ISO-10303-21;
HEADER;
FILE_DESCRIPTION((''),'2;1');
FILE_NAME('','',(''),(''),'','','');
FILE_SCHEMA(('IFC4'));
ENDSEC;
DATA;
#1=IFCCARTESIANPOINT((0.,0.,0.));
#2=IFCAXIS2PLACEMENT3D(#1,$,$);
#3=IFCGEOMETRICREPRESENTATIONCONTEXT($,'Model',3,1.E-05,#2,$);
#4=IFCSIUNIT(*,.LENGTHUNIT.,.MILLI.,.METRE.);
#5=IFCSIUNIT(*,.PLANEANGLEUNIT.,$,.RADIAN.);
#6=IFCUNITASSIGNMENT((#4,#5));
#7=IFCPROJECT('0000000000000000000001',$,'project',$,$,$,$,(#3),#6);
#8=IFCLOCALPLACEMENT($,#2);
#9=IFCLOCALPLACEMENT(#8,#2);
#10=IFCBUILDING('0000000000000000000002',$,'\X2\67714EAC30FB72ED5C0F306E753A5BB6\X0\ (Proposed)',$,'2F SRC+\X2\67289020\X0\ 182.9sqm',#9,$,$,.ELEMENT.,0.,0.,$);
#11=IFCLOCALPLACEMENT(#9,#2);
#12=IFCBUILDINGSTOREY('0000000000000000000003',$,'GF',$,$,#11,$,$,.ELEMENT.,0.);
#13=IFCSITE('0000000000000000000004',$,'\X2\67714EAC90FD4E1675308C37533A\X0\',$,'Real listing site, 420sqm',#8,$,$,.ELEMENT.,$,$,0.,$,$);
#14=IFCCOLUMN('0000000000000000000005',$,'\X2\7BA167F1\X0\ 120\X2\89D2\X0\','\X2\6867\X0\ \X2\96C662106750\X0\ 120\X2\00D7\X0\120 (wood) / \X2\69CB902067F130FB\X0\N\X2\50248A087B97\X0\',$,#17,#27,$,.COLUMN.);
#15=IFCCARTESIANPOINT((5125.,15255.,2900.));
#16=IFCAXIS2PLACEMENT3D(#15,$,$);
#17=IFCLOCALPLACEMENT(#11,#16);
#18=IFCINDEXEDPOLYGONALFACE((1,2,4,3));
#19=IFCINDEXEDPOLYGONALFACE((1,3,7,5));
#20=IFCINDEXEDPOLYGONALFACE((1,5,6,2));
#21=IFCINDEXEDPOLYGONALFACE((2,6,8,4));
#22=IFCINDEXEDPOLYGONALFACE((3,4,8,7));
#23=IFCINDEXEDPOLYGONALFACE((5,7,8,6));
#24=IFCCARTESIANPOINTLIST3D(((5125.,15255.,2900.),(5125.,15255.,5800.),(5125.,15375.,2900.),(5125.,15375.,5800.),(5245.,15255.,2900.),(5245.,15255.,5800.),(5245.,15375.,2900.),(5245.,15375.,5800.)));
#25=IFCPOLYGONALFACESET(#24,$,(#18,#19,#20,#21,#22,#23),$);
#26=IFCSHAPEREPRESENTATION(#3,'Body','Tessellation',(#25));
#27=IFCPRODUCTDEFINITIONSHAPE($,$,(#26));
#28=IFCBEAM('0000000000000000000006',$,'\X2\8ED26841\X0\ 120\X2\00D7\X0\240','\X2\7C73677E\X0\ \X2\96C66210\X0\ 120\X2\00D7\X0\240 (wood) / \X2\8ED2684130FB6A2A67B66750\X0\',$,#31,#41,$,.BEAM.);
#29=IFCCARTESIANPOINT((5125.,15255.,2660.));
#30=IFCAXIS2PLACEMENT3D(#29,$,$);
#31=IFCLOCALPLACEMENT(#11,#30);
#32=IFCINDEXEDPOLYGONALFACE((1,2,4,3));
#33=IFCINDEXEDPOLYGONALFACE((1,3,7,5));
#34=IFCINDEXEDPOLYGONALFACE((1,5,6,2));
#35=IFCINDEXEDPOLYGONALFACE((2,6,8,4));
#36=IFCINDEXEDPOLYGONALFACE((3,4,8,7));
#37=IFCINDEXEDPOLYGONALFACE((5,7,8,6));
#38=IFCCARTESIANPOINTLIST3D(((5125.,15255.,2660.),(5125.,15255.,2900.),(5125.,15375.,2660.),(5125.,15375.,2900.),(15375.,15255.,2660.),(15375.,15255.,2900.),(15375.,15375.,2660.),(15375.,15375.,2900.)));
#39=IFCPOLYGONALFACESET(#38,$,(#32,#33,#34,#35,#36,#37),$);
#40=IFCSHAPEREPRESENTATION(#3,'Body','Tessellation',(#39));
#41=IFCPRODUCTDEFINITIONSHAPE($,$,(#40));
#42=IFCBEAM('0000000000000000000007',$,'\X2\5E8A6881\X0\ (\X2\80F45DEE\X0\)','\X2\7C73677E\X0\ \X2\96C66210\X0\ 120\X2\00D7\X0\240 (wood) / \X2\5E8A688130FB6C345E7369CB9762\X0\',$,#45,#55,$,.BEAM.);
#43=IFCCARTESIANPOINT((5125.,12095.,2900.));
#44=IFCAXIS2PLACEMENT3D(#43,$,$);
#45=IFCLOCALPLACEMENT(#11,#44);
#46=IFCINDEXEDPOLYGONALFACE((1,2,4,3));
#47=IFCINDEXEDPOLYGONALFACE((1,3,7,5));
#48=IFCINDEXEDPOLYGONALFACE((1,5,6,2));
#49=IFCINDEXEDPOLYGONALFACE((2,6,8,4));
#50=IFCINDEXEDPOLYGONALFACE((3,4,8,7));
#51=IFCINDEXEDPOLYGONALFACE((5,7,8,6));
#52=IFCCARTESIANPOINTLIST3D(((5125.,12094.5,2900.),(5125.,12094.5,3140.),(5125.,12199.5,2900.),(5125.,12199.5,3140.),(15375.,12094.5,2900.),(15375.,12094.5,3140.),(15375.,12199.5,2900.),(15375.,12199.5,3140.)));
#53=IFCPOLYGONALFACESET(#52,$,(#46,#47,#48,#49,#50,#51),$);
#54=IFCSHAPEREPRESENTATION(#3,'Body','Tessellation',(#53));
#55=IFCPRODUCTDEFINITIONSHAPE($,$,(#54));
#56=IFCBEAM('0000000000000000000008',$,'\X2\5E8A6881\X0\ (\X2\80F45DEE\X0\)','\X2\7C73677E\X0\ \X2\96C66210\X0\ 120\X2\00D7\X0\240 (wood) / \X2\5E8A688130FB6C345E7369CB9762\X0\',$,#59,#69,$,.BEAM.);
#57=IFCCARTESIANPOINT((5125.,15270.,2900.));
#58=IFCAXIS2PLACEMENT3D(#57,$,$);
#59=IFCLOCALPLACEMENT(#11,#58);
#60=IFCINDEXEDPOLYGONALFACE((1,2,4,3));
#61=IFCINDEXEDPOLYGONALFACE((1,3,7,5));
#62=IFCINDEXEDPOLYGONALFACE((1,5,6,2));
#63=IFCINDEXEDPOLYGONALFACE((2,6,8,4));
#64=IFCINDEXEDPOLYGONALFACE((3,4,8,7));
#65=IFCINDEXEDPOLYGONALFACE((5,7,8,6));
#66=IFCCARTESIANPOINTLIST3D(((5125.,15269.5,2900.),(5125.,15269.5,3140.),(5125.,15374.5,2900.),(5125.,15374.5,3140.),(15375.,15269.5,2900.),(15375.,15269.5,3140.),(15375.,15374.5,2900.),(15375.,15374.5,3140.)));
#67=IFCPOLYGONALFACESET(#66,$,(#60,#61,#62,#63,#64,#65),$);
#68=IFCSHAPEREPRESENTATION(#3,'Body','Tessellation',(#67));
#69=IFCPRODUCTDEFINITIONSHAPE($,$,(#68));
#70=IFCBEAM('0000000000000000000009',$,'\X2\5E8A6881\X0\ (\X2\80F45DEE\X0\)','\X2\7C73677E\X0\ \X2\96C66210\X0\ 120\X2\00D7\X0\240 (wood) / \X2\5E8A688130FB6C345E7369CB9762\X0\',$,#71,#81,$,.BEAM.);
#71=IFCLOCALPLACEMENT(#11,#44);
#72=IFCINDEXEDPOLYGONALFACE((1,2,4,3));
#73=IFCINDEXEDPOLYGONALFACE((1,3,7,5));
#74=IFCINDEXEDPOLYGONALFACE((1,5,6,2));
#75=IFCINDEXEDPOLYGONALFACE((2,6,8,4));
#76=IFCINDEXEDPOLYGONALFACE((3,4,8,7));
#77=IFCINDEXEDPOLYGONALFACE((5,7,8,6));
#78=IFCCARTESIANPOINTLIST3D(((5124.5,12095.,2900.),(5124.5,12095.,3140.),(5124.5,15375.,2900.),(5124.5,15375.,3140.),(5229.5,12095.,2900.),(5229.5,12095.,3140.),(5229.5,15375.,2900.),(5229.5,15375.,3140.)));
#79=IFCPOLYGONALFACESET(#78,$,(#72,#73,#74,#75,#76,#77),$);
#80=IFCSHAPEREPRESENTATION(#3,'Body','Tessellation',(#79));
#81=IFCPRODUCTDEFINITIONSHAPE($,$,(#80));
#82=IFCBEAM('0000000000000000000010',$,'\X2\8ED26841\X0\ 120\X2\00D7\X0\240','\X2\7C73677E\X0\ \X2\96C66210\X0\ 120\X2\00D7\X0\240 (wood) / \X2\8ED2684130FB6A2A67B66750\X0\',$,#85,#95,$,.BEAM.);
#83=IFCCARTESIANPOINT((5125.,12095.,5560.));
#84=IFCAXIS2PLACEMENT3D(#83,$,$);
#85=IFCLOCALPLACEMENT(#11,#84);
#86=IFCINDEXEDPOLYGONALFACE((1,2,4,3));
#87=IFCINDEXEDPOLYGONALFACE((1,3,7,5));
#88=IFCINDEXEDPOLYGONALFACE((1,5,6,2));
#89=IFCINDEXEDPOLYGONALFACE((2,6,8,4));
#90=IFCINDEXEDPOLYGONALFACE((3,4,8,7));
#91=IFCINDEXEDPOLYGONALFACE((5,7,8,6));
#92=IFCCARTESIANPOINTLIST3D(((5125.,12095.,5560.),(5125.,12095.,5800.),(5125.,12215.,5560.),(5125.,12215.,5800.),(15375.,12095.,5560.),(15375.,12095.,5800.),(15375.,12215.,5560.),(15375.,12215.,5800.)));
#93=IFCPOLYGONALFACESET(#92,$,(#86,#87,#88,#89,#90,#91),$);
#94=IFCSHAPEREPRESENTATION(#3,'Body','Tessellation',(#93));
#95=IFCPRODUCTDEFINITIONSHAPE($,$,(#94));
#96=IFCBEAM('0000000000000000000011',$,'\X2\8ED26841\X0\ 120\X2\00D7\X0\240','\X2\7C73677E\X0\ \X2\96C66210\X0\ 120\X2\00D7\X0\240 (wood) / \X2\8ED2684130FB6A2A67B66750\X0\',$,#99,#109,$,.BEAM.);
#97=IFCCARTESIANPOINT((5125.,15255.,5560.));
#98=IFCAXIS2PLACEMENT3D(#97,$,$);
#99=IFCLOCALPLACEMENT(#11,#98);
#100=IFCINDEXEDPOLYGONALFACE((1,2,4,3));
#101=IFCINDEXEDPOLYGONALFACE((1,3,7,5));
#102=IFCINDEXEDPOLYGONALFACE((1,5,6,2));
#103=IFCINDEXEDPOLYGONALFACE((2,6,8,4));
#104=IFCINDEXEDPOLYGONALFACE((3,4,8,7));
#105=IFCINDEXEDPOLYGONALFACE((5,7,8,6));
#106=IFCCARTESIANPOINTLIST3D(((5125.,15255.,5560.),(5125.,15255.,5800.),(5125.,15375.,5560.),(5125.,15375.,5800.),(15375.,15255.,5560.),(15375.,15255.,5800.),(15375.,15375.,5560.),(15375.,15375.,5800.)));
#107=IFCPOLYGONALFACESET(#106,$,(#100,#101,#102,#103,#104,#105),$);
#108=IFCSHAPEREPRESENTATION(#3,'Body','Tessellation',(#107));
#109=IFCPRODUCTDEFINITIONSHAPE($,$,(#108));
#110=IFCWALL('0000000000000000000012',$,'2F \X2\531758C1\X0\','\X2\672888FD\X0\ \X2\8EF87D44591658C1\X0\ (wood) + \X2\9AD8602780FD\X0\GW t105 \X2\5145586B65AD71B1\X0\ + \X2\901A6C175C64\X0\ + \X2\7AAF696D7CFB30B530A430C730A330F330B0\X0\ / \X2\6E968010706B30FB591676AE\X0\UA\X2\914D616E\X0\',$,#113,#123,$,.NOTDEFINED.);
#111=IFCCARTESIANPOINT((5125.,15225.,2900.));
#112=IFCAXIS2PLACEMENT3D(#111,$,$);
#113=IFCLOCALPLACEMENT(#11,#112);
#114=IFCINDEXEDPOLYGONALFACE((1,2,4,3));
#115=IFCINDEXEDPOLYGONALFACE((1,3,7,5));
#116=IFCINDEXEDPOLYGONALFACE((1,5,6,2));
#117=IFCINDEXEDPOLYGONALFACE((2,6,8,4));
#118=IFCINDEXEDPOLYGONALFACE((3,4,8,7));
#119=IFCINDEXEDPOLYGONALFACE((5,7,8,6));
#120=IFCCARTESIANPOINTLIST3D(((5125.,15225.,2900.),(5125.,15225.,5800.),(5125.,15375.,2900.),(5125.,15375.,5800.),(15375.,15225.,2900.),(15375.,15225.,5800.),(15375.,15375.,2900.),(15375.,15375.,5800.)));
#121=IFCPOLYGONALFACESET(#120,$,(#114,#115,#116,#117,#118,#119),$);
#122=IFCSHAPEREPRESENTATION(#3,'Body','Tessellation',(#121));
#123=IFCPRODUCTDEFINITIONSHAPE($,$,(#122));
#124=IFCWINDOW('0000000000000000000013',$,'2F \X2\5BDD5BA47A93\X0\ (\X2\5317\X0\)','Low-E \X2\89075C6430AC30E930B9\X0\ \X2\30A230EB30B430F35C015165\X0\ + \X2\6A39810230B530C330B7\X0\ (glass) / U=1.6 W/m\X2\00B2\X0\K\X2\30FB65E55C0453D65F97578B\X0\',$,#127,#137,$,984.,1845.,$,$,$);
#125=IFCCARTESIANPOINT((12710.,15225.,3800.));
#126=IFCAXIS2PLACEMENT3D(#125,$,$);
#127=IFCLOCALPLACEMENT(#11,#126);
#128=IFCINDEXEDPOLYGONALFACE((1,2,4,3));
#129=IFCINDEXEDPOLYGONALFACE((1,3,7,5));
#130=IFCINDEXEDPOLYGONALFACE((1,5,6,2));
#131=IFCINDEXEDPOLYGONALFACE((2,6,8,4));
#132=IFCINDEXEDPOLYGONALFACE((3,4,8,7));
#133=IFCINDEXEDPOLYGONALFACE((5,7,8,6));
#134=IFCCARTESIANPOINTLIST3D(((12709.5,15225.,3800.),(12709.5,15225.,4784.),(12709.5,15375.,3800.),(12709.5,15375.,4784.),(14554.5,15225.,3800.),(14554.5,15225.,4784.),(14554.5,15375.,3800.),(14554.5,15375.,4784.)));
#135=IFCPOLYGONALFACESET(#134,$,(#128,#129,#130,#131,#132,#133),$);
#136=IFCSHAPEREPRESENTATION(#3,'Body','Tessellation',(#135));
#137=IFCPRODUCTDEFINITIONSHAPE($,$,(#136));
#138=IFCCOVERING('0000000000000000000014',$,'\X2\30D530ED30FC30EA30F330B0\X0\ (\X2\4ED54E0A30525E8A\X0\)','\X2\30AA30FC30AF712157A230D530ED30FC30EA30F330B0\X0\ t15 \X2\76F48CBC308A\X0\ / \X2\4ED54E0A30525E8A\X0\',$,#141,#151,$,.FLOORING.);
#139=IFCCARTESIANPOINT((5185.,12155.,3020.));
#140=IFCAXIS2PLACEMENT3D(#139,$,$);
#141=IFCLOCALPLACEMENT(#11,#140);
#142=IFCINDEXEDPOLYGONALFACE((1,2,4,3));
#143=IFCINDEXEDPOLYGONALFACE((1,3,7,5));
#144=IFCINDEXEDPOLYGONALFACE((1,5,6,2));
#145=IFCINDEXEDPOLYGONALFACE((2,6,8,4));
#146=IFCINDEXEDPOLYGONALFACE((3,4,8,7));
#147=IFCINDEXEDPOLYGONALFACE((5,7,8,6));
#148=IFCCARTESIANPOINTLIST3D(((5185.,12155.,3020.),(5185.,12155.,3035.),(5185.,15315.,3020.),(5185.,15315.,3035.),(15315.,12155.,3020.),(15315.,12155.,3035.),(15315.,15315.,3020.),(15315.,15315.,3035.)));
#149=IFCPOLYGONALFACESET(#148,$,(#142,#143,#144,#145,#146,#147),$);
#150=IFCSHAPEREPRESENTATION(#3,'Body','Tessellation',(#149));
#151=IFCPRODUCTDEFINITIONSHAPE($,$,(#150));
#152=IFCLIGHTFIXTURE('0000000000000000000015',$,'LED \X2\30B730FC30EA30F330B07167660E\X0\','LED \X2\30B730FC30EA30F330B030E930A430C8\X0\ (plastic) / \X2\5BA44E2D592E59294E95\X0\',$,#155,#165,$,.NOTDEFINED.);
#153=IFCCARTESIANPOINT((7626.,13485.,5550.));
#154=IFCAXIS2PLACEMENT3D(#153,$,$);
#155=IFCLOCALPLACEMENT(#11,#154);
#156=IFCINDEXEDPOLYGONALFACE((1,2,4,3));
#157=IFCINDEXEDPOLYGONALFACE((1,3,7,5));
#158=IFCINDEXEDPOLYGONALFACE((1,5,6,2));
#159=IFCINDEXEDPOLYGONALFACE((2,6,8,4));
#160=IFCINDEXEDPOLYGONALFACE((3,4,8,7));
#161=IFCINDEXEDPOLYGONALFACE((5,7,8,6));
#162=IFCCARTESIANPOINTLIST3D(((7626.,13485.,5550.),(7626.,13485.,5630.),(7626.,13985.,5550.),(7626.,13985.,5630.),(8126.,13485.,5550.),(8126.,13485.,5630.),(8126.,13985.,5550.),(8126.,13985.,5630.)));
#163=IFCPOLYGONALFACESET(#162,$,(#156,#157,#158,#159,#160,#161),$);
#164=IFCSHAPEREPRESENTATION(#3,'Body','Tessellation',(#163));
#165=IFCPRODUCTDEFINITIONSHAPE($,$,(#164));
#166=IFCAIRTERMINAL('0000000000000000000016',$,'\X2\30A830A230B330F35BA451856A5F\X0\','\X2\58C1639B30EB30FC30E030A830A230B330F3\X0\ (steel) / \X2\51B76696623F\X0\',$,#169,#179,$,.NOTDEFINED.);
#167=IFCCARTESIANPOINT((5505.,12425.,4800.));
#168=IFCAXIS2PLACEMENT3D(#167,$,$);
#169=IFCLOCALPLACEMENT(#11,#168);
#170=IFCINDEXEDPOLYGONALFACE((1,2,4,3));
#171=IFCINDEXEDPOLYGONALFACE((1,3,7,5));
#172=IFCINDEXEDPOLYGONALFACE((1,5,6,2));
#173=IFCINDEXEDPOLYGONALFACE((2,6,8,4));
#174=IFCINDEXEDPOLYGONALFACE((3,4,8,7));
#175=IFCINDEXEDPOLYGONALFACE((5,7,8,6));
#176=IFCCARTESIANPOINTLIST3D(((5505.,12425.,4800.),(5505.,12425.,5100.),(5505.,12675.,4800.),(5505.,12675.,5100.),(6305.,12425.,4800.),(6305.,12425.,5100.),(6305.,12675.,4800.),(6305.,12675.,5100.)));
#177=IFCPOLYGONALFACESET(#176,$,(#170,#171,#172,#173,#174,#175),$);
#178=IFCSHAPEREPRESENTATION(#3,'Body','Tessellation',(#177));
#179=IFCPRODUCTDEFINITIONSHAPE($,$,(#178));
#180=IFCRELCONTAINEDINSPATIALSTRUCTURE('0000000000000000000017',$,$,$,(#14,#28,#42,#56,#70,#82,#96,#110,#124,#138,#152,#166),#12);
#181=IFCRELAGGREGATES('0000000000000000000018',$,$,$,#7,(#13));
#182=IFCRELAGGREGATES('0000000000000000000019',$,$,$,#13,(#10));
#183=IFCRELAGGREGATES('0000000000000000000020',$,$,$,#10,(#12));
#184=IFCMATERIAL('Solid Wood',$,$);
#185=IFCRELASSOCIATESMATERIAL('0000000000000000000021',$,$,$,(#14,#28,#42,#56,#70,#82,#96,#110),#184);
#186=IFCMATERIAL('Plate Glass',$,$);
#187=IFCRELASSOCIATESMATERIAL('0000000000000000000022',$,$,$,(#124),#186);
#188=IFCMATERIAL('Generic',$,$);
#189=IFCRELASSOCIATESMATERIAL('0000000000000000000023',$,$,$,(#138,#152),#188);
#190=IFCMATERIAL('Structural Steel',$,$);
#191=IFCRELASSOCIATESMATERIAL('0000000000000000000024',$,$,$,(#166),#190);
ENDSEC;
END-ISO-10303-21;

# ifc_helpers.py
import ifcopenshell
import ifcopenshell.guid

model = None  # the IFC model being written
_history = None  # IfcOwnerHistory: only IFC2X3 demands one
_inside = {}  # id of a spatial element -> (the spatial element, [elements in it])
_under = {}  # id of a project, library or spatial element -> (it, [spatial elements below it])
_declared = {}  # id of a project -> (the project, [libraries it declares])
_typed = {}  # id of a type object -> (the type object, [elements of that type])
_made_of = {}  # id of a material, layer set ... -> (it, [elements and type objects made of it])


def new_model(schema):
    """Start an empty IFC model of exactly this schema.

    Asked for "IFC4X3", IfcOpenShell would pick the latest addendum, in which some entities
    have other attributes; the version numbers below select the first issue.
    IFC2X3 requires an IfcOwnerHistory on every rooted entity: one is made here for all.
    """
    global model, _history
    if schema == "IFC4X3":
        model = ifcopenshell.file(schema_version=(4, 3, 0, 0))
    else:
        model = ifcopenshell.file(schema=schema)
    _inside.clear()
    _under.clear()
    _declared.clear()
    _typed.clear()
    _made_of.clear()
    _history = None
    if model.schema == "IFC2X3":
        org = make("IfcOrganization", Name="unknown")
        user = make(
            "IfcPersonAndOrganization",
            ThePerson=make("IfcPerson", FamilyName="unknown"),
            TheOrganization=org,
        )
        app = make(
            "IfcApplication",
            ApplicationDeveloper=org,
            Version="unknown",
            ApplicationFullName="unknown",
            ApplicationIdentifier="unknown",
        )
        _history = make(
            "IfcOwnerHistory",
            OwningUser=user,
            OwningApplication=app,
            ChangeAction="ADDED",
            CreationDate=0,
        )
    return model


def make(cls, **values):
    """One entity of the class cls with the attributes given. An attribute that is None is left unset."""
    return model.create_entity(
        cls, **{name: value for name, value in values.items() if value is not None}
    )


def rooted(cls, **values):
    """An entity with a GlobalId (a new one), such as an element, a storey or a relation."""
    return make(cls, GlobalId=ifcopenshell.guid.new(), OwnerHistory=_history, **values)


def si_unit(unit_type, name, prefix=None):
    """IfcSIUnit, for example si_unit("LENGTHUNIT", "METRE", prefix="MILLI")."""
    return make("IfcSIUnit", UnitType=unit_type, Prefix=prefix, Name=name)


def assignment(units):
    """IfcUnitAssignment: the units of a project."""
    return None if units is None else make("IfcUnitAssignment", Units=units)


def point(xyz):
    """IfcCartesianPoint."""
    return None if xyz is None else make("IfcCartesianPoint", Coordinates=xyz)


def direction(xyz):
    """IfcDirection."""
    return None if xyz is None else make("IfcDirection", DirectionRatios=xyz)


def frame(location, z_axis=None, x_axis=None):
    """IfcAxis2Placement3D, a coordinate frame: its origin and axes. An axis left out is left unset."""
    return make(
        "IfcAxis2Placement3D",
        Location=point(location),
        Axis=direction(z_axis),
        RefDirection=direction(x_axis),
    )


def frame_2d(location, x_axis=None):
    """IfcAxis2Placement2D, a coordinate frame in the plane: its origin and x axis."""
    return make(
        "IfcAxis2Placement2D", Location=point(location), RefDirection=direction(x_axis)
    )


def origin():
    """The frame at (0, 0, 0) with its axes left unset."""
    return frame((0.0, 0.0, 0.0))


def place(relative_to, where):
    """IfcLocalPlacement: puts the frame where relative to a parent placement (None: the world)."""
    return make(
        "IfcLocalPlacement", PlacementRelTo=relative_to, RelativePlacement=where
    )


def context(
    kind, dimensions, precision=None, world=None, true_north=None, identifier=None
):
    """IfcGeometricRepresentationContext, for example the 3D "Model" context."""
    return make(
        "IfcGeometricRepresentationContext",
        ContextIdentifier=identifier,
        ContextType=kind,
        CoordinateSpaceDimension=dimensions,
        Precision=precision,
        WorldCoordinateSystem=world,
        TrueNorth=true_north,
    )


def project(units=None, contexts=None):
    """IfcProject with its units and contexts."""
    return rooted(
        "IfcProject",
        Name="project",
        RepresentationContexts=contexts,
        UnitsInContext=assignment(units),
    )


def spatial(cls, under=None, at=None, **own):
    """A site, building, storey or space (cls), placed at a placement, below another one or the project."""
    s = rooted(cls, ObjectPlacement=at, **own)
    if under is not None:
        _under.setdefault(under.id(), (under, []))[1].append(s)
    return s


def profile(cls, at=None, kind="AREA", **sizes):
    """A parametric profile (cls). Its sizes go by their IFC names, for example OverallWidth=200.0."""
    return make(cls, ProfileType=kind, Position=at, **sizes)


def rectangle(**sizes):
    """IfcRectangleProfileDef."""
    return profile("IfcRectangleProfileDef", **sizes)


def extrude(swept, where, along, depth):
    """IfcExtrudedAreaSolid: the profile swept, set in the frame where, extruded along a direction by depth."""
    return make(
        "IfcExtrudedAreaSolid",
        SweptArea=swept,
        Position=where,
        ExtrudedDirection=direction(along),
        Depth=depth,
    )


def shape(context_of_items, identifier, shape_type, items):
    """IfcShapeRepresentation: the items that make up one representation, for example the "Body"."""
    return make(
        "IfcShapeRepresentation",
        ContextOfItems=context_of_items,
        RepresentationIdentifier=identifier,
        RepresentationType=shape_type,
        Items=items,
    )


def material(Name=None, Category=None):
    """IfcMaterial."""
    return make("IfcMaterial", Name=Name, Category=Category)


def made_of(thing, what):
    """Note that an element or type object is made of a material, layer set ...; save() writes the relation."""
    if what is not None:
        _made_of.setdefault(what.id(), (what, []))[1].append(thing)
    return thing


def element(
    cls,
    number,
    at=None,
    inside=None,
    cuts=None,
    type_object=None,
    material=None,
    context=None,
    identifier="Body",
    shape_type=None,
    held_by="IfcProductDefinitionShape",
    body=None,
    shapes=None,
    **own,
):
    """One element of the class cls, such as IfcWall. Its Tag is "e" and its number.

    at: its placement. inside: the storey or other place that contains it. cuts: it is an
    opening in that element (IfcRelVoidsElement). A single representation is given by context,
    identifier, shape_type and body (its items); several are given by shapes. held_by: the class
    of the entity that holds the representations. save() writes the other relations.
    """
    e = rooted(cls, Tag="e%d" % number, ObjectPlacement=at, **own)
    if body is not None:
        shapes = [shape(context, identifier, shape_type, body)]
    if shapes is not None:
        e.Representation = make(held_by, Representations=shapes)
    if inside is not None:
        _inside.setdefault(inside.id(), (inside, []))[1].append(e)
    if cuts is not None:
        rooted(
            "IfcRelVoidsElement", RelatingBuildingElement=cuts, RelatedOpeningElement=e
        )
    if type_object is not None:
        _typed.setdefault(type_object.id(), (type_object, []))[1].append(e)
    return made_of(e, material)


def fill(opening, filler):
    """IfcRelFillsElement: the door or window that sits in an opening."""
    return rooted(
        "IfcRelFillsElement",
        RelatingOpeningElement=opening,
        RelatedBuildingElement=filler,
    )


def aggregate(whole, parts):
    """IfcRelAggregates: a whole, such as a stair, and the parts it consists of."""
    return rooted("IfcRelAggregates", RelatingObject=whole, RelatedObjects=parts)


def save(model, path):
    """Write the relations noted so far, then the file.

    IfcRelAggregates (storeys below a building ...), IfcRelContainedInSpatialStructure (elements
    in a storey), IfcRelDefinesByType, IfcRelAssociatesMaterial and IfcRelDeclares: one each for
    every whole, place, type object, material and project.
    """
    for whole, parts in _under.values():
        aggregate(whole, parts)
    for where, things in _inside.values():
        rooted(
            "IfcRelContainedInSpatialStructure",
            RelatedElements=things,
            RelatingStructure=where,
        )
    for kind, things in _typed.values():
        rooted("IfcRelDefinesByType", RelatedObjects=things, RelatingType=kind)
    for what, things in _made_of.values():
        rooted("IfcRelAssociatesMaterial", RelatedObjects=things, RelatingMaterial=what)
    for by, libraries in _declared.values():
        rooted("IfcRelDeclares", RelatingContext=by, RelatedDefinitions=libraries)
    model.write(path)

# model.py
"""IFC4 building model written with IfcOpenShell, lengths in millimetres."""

from ifc_helpers import new_model, si_unit, frame, frame_2d, origin, place, context, project, spatial, rectangle, extrude, material, element, fill, save


model = new_model("IFC4")

# Units and contexts
model_context = context("Model", 3, precision=1e-05, world=origin())
ifc_project = project(units=[si_unit("LENGTHUNIT", "METRE", prefix="MILLI"), si_unit("PLANEANGLEUNIT", "RADIAN")], contexts=[model_context])

# Site, building, storey
site_placement = place(None, origin())
site = spatial("IfcSite", under=ifc_project, at=site_placement, Name="東京都世田谷区", ObjectType="Real listing site, 420sqm", CompositionType="ELEMENT", RefElevation=0.0)
building_placement = place(site_placement, origin())
building = spatial("IfcBuilding", under=site, at=building_placement, Name="東京・狭小の町家 (Proposed)", ObjectType="2F SRC+木造 182.9sqm", CompositionType="ELEMENT", ElevationOfRefHeight=0.0, ElevationOfTerrain=0.0)
storey_placement = place(building_placement, origin())
storey = spatial("IfcBuildingStorey", under=building, at=storey_placement, Name="GF", CompositionType="ELEMENT", Elevation=0.0)

# Column
ifc_material_1 = material(Name="Solid Wood")
column_1_placement = place(storey_placement, frame((5125.0, 15255.0, 2900.0)))
element("IfcColumn", 1, at=column_1_placement, inside=storey, material=ifc_material_1, Name="管柱 120角", Description="桧 集成材 120×120 (wood) / 構造柱・N値計算", PredefinedType="COLUMN", context=model_context, shape_type="SweptSolid", body=[
    extrude(rectangle(XDim=120.0, YDim=120.0, at=frame_2d((60.0, 60.0))), frame((5125.0, 15255.0, 2900.0)), (0.0, 0.0, 1.0), 2900.0),
])

# Beams
beam_1_placement = place(storey_placement, frame((5125.0, 15255.0, 2660.0)))
element("IfcBeam", 2, at=beam_1_placement, inside=storey, material=ifc_material_1, Name="軒桁 120×240", Description="米松 集成 120×240 (wood) / 軒桁・横架材", PredefinedType="BEAM", context=model_context, shape_type="SweptSolid", body=[
    extrude(rectangle(XDim=10250.0, YDim=120.0, at=frame_2d((5125.0, 60.0))), frame((5125.0, 15255.0, 2660.0)), (0.0, 0.0, 1.0), 240.0),
])
beam_2_placement = place(storey_placement, frame((5125.0, 12095.0, 2900.0)))
element("IfcBeam", 3, at=beam_2_placement, inside=storey, material=ifc_material_1, Name="床梁 (胴差)", Description="米松 集成 120×240 (wood) / 床梁・水平構面", PredefinedType="BEAM", context=model_context, shape_type="SweptSolid", body=[
    extrude(rectangle(XDim=10250.0, YDim=105.0, at=frame_2d((5125.0, 52.0))), frame((5125.0, 12095.0, 2900.0)), (0.0, 0.0, 1.0), 240.0),
])
beam_3_placement = place(storey_placement, frame((5125.0, 15270.0, 2900.0)))
element("IfcBeam", 4, at=beam_3_placement, inside=storey, material=ifc_material_1, Name="床梁 (胴差)", Description="米松 集成 120×240 (wood) / 床梁・水平構面", PredefinedType="BEAM", context=model_context, shape_type="SweptSolid", body=[
    extrude(rectangle(XDim=10250.0, YDim=105.0, at=frame_2d((5125.0, 52.0))), frame((5125.0, 15270.0, 2900.0)), (0.0, 0.0, 1.0), 240.0),
])
beam_4_placement = place(storey_placement, frame((5125.0, 12095.0, 2900.0)))
element("IfcBeam", 5, at=beam_4_placement, inside=storey, material=ifc_material_1, Name="床梁 (胴差)", Description="米松 集成 120×240 (wood) / 床梁・水平構面", PredefinedType="BEAM", context=model_context, shape_type="SweptSolid", body=[
    extrude(rectangle(XDim=105.0, YDim=3280.0, at=frame_2d((52.0, 1640.0))), frame((5125.0, 12095.0, 2900.0)), (0.0, 0.0, 1.0), 240.0),
])
beam_5_placement = place(storey_placement, frame((5125.0, 12095.0, 5560.0)))
element("IfcBeam", 6, at=beam_5_placement, inside=storey, material=ifc_material_1, Name="軒桁 120×240", Description="米松 集成 120×240 (wood) / 軒桁・横架材", PredefinedType="BEAM", context=model_context, shape_type="SweptSolid", body=[
    extrude(rectangle(XDim=10250.0, YDim=120.0, at=frame_2d((5125.0, 60.0))), frame((5125.0, 12095.0, 5560.0)), (0.0, 0.0, 1.0), 240.0),
])
beam_6_placement = place(storey_placement, frame((5125.0, 15255.0, 5560.0)))
element("IfcBeam", 7, at=beam_6_placement, inside=storey, material=ifc_material_1, Name="軒桁 120×240", Description="米松 集成 120×240 (wood) / 軒桁・横架材", PredefinedType="BEAM", context=model_context, shape_type="SweptSolid", body=[
    extrude(rectangle(XDim=10250.0, YDim=120.0, at=frame_2d((5125.0, 60.0))), frame((5125.0, 15255.0, 5560.0)), (0.0, 0.0, 1.0), 240.0),
])

# Wall, opening, window
wall_placement = place(storey_placement, frame((5125.0, 15225.0, 2900.0)))
wall = element("IfcWall", 8, at=wall_placement, inside=storey, material=ifc_material_1, Name="2F 北壁", Description="木製 軸組外壁 (wood) + 高性能GW t105 充填断熱 + 通気層 + 窯業系サイディング / 準耐火・外皮UA配慮", PredefinedType="NOTDEFINED", context=model_context, shape_type="SweptSolid", body=[
    extrude(rectangle(XDim=10250.0, YDim=150.0, at=frame_2d((5125.0, 75.0))), frame((5125.0, 15225.0, 2900.0)), (0.0, 0.0, 1.0), 2900.0),
])
opening_placement = place(storey_placement, frame((12710.0, 15225.0, 3800.0)))
opening = element("IfcOpeningElement", 9, at=opening_placement, cuts=wall, PredefinedType="NOTDEFINED", context=model_context, shape_type="SweptSolid", body=[
    extrude(rectangle(XDim=1845.0, YDim=150.0, at=frame_2d((922.0, 75.0))), frame((12710.0, 15225.0, 3800.0)), (0.0, 0.0, 1.0), 984.0),
])
ifc_material_2 = material(Name="Plate Glass")
window_placement = place(storey_placement, frame((12710.0, 15225.0, 3800.0)))
window = element("IfcWindow", 10, at=window_placement, inside=storey, material=ifc_material_2, Name="2F 寝室窓 (北)", Description="Low-E 複層ガラス アルゴン封入 + 樹脂サッシ (glass) / U=1.6 W/m²K・日射取得型", OverallHeight=984.0, OverallWidth=1845.0, context=model_context, shape_type="SweptSolid", body=[
    extrude(rectangle(XDim=1845.0, YDim=150.0, at=frame_2d((922.0, 75.0))), frame((12710.0, 15225.0, 3800.0)), (0.0, 0.0, 1.0), 984.0),
])
fill(opening, window)

# Covering
ifc_material_3 = material(Name="Generic")
covering_placement = place(storey_placement, frame((5185.0, 12155.0, 3020.0)))
element("IfcCovering", 11, at=covering_placement, inside=storey, material=ifc_material_3, Name="フローリング (仕上げ床)", Description="オーク無垢フローリング t15 直貼り / 仕上げ床", PredefinedType="FLOORING", context=model_context, shape_type="SweptSolid", body=[
    extrude(rectangle(XDim=10130.0, YDim=3160.0, at=frame_2d((5065.0, 1580.0))), frame((5185.0, 12155.0, 3020.0)), (0.0, 0.0, 1.0), 15.0),
])

# Light fixture
light_fixture_placement = place(storey_placement, frame((7626.0, 13485.0, 5550.0)))
element("IfcLightFixture", 12, at=light_fixture_placement, inside=storey, material=ifc_material_3, Name="LED シーリング照明", Description="LED シーリングライト (plastic) / 室中央天井", PredefinedType="NOTDEFINED", context=model_context, shape_type="SweptSolid", body=[
    extrude(rectangle(XDim=500.0, YDim=500.0, at=frame_2d((250.0, 250.0))), frame((7626.0, 13485.0, 5550.0)), (0.0, 0.0, 1.0), 80.0),
])

# Air terminal
ifc_material_4 = material(Name="Structural Steel")
air_terminal_placement = place(storey_placement, frame((5505.0, 12425.0, 4800.0)))
element("IfcAirTerminal", 13, at=air_terminal_placement, inside=storey, material=ifc_material_4, Name="エアコン室内機", Description="壁掛ルームエアコン (steel) / 冷暖房", PredefinedType="NOTDEFINED", context=model_context, shape_type="SweptSolid", body=[
    extrude(rectangle(XDim=800.0, YDim=250.0, at=frame_2d((400.0, 125.0))), frame((5505.0, 12425.0, 4800.0)), (0.0, 0.0, 1.0), 300.0),
])

save(model, "model.ifc")
